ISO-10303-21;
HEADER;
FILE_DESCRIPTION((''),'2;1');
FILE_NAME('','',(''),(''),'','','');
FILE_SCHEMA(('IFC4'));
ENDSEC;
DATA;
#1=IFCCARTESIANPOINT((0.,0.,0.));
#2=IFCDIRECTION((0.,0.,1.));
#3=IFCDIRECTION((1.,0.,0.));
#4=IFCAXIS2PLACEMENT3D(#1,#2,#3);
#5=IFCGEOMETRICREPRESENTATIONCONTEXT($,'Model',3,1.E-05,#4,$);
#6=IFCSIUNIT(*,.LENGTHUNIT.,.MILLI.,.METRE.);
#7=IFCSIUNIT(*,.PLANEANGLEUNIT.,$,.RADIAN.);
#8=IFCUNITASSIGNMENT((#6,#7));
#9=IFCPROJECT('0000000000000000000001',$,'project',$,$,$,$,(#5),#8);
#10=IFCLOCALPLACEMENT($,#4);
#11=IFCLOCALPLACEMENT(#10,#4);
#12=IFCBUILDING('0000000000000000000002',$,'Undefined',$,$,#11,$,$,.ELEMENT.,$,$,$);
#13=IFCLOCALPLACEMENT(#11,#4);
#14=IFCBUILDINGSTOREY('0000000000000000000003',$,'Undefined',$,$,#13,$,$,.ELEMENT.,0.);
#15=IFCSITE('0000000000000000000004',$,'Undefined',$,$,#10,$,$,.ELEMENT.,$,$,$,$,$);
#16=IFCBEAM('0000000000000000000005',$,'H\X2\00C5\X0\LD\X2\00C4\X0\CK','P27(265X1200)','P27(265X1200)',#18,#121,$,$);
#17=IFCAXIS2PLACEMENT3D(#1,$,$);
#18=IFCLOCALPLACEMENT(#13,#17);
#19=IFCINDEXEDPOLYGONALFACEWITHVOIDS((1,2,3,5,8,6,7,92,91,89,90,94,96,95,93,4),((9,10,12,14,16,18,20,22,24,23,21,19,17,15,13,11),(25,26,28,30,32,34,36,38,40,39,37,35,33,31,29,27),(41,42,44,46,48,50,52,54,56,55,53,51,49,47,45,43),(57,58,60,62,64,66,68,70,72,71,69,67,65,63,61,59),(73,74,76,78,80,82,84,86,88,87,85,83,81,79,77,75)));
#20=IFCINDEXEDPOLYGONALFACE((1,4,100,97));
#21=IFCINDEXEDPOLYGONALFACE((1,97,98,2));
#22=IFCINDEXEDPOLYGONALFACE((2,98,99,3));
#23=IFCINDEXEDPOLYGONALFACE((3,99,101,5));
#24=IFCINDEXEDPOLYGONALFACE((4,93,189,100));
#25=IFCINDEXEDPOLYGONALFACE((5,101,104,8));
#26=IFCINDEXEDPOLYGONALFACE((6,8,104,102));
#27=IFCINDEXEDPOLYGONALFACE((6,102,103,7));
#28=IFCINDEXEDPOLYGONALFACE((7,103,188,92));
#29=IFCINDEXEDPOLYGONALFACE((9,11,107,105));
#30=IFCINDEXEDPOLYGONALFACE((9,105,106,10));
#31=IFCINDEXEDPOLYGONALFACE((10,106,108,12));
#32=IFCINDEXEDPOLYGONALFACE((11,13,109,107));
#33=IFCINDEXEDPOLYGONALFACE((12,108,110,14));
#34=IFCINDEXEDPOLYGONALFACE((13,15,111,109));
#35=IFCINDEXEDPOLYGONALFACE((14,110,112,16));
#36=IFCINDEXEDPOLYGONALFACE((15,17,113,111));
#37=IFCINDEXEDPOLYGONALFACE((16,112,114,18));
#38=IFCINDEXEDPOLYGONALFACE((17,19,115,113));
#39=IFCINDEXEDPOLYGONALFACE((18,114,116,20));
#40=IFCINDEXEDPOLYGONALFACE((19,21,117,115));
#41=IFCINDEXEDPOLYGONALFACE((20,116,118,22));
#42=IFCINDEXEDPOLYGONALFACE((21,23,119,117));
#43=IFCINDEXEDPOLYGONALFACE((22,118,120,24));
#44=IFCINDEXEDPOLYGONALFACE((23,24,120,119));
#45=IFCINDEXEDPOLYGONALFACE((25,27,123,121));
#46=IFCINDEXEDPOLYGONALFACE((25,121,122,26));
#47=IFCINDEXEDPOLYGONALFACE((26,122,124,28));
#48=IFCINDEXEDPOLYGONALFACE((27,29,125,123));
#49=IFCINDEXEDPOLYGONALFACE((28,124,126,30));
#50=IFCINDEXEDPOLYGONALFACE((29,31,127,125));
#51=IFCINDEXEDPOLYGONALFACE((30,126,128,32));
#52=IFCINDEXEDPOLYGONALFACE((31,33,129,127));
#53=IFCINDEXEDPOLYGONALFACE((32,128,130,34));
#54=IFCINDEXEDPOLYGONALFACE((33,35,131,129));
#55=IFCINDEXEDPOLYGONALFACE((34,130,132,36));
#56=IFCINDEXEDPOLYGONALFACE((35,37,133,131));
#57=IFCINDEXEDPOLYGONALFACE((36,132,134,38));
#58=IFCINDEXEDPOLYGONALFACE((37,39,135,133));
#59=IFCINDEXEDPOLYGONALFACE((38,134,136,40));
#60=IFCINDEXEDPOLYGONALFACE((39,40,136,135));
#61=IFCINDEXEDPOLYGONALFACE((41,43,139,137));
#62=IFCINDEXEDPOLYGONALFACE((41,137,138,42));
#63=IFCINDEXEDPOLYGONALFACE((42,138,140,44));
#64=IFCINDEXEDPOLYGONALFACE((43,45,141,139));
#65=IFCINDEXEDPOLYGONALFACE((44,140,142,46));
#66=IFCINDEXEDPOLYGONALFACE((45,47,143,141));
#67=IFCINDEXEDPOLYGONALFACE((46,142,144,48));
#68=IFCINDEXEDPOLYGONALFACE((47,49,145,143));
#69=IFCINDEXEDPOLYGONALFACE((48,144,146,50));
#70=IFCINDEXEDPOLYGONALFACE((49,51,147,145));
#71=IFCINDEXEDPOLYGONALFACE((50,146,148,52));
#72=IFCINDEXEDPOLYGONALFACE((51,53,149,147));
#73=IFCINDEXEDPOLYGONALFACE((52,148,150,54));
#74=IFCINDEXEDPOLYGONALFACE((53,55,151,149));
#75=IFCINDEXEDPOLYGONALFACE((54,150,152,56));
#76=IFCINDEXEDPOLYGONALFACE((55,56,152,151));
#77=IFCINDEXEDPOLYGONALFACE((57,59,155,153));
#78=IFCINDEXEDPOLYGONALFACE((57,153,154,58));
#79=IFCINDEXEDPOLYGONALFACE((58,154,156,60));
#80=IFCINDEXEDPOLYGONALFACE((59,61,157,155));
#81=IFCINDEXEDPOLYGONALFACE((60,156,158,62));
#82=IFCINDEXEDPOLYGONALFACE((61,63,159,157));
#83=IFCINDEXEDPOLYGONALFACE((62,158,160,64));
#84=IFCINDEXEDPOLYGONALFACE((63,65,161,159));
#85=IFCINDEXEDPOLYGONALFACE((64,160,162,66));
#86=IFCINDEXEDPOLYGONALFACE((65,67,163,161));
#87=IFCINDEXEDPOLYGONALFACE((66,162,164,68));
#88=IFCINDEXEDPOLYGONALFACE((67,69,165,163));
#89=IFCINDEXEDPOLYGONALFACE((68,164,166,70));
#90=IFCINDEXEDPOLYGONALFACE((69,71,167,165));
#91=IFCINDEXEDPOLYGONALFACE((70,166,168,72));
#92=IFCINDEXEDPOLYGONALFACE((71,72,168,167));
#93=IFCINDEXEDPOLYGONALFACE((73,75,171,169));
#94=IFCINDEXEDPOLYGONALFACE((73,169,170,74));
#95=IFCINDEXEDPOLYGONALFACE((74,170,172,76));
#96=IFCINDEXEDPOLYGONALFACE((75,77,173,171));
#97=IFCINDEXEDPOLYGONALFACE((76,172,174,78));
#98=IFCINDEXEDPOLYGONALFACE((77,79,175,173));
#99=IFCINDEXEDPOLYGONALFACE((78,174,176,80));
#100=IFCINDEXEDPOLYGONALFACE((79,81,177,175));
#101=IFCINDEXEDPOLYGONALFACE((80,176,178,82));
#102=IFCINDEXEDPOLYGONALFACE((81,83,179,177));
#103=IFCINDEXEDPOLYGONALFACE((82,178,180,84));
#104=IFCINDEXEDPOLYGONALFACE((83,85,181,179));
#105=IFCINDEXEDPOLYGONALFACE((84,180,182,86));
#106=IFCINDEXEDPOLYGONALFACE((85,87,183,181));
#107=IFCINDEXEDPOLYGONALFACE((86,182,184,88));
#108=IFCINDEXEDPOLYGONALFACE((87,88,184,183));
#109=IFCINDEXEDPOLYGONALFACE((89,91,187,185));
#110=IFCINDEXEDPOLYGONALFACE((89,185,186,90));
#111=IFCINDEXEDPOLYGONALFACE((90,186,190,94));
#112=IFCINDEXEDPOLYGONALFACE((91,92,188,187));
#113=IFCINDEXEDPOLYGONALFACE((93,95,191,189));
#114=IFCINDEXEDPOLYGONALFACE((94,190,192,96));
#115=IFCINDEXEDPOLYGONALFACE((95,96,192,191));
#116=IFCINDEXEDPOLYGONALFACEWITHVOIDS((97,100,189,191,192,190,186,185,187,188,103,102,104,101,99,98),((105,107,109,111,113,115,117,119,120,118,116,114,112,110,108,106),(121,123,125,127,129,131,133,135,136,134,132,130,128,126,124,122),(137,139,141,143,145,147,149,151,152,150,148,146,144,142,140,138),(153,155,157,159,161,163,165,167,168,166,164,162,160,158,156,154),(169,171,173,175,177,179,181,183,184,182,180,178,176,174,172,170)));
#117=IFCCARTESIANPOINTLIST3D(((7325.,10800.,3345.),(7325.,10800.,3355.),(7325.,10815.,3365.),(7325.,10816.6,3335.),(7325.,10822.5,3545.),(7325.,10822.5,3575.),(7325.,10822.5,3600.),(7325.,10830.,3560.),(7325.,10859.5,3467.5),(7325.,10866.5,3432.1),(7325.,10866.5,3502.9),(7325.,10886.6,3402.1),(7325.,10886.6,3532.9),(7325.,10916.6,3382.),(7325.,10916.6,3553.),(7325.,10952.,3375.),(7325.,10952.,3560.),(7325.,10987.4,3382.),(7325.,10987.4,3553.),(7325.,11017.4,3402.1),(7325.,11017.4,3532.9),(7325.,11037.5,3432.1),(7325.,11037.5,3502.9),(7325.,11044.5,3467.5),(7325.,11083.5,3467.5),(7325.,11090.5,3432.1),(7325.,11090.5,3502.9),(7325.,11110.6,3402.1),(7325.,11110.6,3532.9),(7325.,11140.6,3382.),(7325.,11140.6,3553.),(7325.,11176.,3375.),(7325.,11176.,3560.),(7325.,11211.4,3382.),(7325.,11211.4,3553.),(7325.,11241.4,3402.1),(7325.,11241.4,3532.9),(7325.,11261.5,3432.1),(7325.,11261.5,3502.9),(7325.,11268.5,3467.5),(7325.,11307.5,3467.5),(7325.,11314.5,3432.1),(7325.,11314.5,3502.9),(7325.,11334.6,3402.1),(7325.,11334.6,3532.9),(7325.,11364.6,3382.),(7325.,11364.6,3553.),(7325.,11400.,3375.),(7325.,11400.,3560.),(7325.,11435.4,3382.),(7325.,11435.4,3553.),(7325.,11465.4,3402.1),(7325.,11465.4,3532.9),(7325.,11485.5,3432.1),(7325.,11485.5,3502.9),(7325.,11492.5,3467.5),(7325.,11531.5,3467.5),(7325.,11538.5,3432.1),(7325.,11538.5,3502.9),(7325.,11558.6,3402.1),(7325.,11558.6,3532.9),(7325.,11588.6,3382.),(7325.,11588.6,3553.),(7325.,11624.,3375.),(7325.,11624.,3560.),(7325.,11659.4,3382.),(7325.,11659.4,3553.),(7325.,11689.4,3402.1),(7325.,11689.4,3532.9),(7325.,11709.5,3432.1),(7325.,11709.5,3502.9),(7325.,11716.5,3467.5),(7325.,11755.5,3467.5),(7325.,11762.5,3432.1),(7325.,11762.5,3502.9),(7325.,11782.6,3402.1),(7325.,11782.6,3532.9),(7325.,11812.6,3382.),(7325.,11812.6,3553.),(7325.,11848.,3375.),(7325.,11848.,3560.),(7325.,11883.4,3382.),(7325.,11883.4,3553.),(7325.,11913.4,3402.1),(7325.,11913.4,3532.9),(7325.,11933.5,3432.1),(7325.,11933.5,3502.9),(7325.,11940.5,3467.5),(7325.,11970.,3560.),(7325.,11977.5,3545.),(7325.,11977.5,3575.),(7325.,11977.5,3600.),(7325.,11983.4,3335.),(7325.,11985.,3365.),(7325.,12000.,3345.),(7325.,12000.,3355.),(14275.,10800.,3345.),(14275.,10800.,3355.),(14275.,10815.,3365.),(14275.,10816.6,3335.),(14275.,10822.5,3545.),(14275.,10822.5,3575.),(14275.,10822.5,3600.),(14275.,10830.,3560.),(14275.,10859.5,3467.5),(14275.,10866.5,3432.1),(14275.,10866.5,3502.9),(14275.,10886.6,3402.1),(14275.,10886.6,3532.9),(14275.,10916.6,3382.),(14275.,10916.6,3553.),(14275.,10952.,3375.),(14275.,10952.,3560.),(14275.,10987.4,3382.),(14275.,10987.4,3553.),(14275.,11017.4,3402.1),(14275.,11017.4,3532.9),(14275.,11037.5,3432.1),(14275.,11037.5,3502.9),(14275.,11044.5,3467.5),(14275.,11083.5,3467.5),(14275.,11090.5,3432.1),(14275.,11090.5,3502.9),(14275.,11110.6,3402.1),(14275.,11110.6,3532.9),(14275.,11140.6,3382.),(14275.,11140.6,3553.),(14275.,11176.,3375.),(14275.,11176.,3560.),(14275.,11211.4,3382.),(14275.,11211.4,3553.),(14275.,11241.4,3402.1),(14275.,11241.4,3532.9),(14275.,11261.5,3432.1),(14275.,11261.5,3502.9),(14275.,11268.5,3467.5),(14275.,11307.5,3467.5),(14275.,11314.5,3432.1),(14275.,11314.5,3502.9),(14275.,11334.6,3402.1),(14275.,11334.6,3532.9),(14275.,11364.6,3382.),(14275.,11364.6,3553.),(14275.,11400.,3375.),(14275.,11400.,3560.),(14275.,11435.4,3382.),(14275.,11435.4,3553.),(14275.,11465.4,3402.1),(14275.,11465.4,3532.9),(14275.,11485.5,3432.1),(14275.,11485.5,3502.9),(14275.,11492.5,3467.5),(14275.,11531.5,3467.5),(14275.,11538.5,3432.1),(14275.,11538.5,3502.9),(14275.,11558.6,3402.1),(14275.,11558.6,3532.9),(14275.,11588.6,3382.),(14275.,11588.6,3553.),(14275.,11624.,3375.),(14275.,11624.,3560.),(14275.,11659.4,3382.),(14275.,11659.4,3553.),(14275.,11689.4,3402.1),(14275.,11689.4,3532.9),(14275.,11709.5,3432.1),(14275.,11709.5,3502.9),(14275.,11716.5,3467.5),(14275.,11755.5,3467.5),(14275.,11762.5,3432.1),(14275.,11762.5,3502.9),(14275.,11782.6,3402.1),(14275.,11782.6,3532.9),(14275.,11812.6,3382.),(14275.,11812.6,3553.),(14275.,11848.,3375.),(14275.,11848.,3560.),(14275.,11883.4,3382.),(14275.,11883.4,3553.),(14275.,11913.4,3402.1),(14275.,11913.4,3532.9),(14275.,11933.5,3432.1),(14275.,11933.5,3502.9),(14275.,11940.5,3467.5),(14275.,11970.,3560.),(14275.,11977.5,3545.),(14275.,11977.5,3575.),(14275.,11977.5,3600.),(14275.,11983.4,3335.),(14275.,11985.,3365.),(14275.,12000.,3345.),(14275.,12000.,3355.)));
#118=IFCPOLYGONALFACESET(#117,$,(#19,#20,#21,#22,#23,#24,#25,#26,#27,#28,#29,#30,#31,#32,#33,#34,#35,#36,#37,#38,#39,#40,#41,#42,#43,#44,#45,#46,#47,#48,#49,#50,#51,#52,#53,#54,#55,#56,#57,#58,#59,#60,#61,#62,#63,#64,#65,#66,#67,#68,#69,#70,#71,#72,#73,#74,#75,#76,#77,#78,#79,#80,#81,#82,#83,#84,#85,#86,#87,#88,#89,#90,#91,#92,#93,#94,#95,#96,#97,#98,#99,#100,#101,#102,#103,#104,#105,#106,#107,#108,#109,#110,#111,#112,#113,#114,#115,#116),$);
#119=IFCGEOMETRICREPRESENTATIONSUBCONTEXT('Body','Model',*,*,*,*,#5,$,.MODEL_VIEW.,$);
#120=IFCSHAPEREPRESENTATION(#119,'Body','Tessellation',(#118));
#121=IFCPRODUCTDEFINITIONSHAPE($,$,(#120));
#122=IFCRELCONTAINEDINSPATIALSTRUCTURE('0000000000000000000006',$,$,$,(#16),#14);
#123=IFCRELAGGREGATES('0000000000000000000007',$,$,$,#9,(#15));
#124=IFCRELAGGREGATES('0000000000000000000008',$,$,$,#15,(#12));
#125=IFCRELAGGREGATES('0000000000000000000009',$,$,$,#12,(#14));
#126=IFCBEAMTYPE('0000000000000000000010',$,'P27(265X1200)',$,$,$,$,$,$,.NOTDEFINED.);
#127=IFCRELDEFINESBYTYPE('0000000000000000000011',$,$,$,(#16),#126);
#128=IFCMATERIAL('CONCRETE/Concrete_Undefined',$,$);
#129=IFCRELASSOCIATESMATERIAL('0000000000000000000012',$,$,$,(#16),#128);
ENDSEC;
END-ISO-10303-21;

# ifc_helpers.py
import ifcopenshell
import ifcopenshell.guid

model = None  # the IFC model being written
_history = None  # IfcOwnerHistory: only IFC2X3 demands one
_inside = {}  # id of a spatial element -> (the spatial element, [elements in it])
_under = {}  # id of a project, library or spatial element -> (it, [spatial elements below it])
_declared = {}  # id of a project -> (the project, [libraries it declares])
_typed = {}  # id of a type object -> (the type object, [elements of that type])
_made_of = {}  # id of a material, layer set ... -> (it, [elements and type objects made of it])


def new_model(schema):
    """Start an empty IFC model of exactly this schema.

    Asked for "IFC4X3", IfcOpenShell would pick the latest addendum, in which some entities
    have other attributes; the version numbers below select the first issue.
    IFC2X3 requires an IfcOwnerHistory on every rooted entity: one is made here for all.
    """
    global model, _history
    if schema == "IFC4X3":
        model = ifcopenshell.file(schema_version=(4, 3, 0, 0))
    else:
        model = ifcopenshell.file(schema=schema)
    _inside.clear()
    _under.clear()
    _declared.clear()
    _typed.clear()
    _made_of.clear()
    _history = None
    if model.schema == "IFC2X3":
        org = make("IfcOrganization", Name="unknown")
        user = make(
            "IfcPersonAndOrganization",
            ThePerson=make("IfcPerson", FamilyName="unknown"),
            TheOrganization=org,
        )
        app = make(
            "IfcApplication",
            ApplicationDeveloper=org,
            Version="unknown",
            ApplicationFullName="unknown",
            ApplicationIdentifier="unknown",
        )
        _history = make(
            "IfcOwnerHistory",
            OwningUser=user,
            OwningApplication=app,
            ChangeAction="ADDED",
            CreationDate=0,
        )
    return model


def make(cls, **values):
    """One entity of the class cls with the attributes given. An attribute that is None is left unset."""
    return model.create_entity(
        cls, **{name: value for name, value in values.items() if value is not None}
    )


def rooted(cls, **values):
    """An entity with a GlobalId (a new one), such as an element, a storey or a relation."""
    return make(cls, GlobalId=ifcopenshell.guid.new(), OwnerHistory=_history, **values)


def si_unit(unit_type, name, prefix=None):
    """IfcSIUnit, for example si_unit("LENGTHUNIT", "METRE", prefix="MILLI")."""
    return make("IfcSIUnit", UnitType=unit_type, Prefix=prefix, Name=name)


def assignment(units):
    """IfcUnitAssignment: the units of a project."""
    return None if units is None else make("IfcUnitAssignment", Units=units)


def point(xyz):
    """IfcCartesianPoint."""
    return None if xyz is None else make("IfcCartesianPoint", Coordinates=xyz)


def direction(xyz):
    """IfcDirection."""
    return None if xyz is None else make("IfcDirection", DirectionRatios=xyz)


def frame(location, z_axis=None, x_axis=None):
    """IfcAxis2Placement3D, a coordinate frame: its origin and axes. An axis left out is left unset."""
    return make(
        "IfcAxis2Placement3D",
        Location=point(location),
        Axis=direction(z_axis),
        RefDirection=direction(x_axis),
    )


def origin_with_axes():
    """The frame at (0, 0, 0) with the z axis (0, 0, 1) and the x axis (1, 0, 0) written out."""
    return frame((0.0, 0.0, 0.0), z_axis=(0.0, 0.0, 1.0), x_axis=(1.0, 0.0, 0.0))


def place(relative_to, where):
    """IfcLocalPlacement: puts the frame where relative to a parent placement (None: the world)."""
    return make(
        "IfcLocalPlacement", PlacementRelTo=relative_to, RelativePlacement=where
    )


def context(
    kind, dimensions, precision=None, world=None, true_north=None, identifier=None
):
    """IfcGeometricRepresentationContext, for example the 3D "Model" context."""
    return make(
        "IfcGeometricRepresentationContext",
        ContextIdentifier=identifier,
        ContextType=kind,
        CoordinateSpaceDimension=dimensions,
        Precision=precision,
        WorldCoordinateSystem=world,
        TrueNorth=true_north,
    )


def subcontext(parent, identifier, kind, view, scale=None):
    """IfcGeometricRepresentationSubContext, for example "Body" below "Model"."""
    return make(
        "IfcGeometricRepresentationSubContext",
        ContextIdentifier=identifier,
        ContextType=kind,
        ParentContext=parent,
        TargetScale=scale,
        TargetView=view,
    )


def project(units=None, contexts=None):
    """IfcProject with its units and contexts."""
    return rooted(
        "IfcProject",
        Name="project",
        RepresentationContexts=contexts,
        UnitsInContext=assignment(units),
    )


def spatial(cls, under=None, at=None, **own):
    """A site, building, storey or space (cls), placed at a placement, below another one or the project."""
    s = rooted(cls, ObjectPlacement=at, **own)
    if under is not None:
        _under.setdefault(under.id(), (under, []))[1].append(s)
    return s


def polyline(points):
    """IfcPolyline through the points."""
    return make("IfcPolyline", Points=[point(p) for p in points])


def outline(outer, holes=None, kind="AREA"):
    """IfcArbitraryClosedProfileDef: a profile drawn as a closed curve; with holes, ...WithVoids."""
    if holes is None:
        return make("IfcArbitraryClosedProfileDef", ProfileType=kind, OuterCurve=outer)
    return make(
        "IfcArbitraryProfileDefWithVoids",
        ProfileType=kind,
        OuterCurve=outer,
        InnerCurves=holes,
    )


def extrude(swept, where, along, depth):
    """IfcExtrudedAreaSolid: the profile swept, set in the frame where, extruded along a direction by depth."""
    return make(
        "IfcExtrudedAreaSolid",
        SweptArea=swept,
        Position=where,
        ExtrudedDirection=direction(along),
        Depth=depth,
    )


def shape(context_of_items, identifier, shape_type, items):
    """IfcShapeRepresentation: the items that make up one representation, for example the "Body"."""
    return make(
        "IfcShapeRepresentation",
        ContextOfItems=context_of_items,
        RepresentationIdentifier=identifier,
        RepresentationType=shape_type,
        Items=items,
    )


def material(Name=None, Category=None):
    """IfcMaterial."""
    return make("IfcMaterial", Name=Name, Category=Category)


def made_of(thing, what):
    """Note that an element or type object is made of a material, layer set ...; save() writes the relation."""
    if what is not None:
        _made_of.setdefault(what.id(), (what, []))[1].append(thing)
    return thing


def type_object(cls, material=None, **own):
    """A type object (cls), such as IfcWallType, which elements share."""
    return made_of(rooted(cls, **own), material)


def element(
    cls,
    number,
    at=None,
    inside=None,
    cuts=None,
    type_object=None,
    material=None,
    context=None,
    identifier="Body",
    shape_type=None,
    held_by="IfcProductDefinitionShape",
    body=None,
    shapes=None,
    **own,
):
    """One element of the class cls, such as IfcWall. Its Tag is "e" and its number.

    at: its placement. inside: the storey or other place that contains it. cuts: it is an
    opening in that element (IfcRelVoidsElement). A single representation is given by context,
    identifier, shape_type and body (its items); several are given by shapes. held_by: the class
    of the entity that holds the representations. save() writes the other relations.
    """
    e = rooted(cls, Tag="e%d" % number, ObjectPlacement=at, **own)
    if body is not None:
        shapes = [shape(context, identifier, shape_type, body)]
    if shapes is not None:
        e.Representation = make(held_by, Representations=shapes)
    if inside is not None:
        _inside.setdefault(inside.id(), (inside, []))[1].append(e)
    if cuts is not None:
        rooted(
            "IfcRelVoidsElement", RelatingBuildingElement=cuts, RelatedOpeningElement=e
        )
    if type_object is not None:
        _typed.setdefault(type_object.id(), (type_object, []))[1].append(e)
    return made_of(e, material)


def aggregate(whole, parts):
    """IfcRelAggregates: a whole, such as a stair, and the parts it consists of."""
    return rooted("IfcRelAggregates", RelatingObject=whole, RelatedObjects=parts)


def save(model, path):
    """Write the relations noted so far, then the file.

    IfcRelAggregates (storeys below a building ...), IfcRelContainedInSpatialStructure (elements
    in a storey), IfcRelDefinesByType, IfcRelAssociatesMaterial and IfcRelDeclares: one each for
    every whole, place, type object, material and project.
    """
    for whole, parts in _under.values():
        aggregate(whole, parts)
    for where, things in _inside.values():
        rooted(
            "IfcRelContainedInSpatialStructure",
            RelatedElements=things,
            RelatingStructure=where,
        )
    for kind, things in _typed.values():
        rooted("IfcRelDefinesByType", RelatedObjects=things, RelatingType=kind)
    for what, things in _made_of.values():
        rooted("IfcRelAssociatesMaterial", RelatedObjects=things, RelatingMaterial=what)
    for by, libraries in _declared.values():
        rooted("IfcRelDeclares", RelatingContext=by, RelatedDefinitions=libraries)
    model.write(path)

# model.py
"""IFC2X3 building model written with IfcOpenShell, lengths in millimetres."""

from ifc_helpers import new_model, si_unit, frame, origin_with_axes, place, context, subcontext, project, spatial, polyline, outline, extrude, material, type_object, element, save


model = new_model("IFC2X3")

# Units and contexts
model_context = context("Model", 3, precision=1e-05, world=origin_with_axes())
body_context = subcontext(model_context, "Body", "Model", "MODEL_VIEW")
ifc_project = project(units=[si_unit("LENGTHUNIT", "METRE", prefix="MILLI"), si_unit("PLANEANGLEUNIT", "RADIAN")], contexts=[model_context])

# Site, building, storey
site_placement = place(None, origin_with_axes())
site = spatial("IfcSite", under=ifc_project, at=site_placement, Name="Undefined", CompositionType="ELEMENT")
building_placement = place(site_placement, origin_with_axes())
building = spatial("IfcBuilding", under=site, at=building_placement, Name="Undefined", CompositionType="ELEMENT")
storey_placement = place(building_placement, origin_with_axes())
storey = spatial("IfcBuildingStorey", under=building, at=storey_placement, Name="Undefined", CompositionType="ELEMENT", Elevation=0.0)

# Beam
ifc_material_1 = material(Name="CONCRETE/Concrete_Undefined")
beam_type_1 = type_object("IfcBeamType", Name="P27(265X1200)", PredefinedType="NOTDEFINED")
beam_1_placement = place(storey_placement, frame((7325.0, 11400.0, 3467.5), z_axis=(0.0, 0.0, 1.0), x_axis=(1.0, 0.0, 0.0)))
element("IfcBeam", 1, at=beam_1_placement, inside=storey, type_object=beam_type_1, material=ifc_material_1, Name="HÅLDÄCK", Description="P27(265X1200)", ObjectType="P27(265X1200)", context=body_context, shape_type="SweptSolid", body=[
    extrude(outline(polyline([(-583.4, -132.5), (-600.0, -122.5), (-600.0, -112.5), (-585.0, -102.5), (-577.5, 77.5), (-570.0, 92.5), (-577.5, 107.5), (-577.5, 132.5), (577.5, 132.5), (577.5, 107.5), (570.0, 92.5), (577.5, 77.5), (585.0, -102.5), (600.0, -112.5), (600.0, -122.5), (583.4, -132.5), (-583.4, -132.5)]), holes=[polyline([(-513.4, 65.4), (-533.5, 35.4), (-540.5, 0.0), (-533.5, -35.4), (-513.4, -65.4), (-483.4, -85.5), (-448.0, -92.5), (-412.6, -85.5), (-382.6, -65.4), (-362.5, -35.4), (-355.5, 0.0), (-362.5, 35.4), (-382.6, 65.4), (-412.6, 85.5), (-448.0, 92.5), (-483.4, 85.5), (-513.4, 65.4)]), polyline([(-289.4, 65.4), (-309.5, 35.4), (-316.5, 0.0), (-309.5, -35.4), (-289.4, -65.4), (-259.4, -85.5), (-224.0, -92.5), (-188.6, -85.5), (-158.6, -65.4), (-138.5, -35.4), (-131.5, 0.0), (-138.5, 35.4), (-158.6, 65.4), (-188.6, 85.5), (-224.0, 92.5), (-259.4, 85.5), (-289.4, 65.4)]), polyline([(-65.4, 65.4), (-85.5, 35.4), (-92.5, 0.0), (-85.5, -35.4), (-65.4, -65.4), (-35.4, -85.5), (0.0, -92.5), (35.4, -85.5), (65.4, -65.4), (85.5, -35.4), (92.5, 0.0), (85.5, 35.4), (65.4, 65.4), (35.4, 85.5), (0.0, 92.5), (-35.4, 85.5), (-65.4, 65.4)]), polyline([(158.6, 65.4), (138.5, 35.4), (131.5, 0.0), (138.5, -35.4), (158.6, -65.4), (188.6, -85.5), (224.0, -92.5), (259.4, -85.5), (289.4, -65.4), (309.5, -35.4), (316.5, 0.0), (309.5, 35.4), (289.4, 65.4), (259.4, 85.5), (224.0, 92.5), (188.6, 85.5), (158.6, 65.4)]), polyline([(382.6, 65.4), (362.5, 35.4), (355.5, 0.0), (362.5, -35.4), (382.6, -65.4), (412.6, -85.5), (448.0, -92.5), (483.4, -85.5), (513.4, -65.4), (533.5, -35.4), (540.5, 0.0), (533.5, 35.4), (513.4, 65.4), (483.4, 85.5), (448.0, 92.5), (412.6, 85.5), (382.6, 65.4)])]), frame((6950.0, 0.0, 0.0), z_axis=(-1.0, 0.0, 0.0), x_axis=(0.0, -1.0, 0.0)), (0.0, 0.0, 1.0), 6950.0),
])

save(model, "model.ifc")
